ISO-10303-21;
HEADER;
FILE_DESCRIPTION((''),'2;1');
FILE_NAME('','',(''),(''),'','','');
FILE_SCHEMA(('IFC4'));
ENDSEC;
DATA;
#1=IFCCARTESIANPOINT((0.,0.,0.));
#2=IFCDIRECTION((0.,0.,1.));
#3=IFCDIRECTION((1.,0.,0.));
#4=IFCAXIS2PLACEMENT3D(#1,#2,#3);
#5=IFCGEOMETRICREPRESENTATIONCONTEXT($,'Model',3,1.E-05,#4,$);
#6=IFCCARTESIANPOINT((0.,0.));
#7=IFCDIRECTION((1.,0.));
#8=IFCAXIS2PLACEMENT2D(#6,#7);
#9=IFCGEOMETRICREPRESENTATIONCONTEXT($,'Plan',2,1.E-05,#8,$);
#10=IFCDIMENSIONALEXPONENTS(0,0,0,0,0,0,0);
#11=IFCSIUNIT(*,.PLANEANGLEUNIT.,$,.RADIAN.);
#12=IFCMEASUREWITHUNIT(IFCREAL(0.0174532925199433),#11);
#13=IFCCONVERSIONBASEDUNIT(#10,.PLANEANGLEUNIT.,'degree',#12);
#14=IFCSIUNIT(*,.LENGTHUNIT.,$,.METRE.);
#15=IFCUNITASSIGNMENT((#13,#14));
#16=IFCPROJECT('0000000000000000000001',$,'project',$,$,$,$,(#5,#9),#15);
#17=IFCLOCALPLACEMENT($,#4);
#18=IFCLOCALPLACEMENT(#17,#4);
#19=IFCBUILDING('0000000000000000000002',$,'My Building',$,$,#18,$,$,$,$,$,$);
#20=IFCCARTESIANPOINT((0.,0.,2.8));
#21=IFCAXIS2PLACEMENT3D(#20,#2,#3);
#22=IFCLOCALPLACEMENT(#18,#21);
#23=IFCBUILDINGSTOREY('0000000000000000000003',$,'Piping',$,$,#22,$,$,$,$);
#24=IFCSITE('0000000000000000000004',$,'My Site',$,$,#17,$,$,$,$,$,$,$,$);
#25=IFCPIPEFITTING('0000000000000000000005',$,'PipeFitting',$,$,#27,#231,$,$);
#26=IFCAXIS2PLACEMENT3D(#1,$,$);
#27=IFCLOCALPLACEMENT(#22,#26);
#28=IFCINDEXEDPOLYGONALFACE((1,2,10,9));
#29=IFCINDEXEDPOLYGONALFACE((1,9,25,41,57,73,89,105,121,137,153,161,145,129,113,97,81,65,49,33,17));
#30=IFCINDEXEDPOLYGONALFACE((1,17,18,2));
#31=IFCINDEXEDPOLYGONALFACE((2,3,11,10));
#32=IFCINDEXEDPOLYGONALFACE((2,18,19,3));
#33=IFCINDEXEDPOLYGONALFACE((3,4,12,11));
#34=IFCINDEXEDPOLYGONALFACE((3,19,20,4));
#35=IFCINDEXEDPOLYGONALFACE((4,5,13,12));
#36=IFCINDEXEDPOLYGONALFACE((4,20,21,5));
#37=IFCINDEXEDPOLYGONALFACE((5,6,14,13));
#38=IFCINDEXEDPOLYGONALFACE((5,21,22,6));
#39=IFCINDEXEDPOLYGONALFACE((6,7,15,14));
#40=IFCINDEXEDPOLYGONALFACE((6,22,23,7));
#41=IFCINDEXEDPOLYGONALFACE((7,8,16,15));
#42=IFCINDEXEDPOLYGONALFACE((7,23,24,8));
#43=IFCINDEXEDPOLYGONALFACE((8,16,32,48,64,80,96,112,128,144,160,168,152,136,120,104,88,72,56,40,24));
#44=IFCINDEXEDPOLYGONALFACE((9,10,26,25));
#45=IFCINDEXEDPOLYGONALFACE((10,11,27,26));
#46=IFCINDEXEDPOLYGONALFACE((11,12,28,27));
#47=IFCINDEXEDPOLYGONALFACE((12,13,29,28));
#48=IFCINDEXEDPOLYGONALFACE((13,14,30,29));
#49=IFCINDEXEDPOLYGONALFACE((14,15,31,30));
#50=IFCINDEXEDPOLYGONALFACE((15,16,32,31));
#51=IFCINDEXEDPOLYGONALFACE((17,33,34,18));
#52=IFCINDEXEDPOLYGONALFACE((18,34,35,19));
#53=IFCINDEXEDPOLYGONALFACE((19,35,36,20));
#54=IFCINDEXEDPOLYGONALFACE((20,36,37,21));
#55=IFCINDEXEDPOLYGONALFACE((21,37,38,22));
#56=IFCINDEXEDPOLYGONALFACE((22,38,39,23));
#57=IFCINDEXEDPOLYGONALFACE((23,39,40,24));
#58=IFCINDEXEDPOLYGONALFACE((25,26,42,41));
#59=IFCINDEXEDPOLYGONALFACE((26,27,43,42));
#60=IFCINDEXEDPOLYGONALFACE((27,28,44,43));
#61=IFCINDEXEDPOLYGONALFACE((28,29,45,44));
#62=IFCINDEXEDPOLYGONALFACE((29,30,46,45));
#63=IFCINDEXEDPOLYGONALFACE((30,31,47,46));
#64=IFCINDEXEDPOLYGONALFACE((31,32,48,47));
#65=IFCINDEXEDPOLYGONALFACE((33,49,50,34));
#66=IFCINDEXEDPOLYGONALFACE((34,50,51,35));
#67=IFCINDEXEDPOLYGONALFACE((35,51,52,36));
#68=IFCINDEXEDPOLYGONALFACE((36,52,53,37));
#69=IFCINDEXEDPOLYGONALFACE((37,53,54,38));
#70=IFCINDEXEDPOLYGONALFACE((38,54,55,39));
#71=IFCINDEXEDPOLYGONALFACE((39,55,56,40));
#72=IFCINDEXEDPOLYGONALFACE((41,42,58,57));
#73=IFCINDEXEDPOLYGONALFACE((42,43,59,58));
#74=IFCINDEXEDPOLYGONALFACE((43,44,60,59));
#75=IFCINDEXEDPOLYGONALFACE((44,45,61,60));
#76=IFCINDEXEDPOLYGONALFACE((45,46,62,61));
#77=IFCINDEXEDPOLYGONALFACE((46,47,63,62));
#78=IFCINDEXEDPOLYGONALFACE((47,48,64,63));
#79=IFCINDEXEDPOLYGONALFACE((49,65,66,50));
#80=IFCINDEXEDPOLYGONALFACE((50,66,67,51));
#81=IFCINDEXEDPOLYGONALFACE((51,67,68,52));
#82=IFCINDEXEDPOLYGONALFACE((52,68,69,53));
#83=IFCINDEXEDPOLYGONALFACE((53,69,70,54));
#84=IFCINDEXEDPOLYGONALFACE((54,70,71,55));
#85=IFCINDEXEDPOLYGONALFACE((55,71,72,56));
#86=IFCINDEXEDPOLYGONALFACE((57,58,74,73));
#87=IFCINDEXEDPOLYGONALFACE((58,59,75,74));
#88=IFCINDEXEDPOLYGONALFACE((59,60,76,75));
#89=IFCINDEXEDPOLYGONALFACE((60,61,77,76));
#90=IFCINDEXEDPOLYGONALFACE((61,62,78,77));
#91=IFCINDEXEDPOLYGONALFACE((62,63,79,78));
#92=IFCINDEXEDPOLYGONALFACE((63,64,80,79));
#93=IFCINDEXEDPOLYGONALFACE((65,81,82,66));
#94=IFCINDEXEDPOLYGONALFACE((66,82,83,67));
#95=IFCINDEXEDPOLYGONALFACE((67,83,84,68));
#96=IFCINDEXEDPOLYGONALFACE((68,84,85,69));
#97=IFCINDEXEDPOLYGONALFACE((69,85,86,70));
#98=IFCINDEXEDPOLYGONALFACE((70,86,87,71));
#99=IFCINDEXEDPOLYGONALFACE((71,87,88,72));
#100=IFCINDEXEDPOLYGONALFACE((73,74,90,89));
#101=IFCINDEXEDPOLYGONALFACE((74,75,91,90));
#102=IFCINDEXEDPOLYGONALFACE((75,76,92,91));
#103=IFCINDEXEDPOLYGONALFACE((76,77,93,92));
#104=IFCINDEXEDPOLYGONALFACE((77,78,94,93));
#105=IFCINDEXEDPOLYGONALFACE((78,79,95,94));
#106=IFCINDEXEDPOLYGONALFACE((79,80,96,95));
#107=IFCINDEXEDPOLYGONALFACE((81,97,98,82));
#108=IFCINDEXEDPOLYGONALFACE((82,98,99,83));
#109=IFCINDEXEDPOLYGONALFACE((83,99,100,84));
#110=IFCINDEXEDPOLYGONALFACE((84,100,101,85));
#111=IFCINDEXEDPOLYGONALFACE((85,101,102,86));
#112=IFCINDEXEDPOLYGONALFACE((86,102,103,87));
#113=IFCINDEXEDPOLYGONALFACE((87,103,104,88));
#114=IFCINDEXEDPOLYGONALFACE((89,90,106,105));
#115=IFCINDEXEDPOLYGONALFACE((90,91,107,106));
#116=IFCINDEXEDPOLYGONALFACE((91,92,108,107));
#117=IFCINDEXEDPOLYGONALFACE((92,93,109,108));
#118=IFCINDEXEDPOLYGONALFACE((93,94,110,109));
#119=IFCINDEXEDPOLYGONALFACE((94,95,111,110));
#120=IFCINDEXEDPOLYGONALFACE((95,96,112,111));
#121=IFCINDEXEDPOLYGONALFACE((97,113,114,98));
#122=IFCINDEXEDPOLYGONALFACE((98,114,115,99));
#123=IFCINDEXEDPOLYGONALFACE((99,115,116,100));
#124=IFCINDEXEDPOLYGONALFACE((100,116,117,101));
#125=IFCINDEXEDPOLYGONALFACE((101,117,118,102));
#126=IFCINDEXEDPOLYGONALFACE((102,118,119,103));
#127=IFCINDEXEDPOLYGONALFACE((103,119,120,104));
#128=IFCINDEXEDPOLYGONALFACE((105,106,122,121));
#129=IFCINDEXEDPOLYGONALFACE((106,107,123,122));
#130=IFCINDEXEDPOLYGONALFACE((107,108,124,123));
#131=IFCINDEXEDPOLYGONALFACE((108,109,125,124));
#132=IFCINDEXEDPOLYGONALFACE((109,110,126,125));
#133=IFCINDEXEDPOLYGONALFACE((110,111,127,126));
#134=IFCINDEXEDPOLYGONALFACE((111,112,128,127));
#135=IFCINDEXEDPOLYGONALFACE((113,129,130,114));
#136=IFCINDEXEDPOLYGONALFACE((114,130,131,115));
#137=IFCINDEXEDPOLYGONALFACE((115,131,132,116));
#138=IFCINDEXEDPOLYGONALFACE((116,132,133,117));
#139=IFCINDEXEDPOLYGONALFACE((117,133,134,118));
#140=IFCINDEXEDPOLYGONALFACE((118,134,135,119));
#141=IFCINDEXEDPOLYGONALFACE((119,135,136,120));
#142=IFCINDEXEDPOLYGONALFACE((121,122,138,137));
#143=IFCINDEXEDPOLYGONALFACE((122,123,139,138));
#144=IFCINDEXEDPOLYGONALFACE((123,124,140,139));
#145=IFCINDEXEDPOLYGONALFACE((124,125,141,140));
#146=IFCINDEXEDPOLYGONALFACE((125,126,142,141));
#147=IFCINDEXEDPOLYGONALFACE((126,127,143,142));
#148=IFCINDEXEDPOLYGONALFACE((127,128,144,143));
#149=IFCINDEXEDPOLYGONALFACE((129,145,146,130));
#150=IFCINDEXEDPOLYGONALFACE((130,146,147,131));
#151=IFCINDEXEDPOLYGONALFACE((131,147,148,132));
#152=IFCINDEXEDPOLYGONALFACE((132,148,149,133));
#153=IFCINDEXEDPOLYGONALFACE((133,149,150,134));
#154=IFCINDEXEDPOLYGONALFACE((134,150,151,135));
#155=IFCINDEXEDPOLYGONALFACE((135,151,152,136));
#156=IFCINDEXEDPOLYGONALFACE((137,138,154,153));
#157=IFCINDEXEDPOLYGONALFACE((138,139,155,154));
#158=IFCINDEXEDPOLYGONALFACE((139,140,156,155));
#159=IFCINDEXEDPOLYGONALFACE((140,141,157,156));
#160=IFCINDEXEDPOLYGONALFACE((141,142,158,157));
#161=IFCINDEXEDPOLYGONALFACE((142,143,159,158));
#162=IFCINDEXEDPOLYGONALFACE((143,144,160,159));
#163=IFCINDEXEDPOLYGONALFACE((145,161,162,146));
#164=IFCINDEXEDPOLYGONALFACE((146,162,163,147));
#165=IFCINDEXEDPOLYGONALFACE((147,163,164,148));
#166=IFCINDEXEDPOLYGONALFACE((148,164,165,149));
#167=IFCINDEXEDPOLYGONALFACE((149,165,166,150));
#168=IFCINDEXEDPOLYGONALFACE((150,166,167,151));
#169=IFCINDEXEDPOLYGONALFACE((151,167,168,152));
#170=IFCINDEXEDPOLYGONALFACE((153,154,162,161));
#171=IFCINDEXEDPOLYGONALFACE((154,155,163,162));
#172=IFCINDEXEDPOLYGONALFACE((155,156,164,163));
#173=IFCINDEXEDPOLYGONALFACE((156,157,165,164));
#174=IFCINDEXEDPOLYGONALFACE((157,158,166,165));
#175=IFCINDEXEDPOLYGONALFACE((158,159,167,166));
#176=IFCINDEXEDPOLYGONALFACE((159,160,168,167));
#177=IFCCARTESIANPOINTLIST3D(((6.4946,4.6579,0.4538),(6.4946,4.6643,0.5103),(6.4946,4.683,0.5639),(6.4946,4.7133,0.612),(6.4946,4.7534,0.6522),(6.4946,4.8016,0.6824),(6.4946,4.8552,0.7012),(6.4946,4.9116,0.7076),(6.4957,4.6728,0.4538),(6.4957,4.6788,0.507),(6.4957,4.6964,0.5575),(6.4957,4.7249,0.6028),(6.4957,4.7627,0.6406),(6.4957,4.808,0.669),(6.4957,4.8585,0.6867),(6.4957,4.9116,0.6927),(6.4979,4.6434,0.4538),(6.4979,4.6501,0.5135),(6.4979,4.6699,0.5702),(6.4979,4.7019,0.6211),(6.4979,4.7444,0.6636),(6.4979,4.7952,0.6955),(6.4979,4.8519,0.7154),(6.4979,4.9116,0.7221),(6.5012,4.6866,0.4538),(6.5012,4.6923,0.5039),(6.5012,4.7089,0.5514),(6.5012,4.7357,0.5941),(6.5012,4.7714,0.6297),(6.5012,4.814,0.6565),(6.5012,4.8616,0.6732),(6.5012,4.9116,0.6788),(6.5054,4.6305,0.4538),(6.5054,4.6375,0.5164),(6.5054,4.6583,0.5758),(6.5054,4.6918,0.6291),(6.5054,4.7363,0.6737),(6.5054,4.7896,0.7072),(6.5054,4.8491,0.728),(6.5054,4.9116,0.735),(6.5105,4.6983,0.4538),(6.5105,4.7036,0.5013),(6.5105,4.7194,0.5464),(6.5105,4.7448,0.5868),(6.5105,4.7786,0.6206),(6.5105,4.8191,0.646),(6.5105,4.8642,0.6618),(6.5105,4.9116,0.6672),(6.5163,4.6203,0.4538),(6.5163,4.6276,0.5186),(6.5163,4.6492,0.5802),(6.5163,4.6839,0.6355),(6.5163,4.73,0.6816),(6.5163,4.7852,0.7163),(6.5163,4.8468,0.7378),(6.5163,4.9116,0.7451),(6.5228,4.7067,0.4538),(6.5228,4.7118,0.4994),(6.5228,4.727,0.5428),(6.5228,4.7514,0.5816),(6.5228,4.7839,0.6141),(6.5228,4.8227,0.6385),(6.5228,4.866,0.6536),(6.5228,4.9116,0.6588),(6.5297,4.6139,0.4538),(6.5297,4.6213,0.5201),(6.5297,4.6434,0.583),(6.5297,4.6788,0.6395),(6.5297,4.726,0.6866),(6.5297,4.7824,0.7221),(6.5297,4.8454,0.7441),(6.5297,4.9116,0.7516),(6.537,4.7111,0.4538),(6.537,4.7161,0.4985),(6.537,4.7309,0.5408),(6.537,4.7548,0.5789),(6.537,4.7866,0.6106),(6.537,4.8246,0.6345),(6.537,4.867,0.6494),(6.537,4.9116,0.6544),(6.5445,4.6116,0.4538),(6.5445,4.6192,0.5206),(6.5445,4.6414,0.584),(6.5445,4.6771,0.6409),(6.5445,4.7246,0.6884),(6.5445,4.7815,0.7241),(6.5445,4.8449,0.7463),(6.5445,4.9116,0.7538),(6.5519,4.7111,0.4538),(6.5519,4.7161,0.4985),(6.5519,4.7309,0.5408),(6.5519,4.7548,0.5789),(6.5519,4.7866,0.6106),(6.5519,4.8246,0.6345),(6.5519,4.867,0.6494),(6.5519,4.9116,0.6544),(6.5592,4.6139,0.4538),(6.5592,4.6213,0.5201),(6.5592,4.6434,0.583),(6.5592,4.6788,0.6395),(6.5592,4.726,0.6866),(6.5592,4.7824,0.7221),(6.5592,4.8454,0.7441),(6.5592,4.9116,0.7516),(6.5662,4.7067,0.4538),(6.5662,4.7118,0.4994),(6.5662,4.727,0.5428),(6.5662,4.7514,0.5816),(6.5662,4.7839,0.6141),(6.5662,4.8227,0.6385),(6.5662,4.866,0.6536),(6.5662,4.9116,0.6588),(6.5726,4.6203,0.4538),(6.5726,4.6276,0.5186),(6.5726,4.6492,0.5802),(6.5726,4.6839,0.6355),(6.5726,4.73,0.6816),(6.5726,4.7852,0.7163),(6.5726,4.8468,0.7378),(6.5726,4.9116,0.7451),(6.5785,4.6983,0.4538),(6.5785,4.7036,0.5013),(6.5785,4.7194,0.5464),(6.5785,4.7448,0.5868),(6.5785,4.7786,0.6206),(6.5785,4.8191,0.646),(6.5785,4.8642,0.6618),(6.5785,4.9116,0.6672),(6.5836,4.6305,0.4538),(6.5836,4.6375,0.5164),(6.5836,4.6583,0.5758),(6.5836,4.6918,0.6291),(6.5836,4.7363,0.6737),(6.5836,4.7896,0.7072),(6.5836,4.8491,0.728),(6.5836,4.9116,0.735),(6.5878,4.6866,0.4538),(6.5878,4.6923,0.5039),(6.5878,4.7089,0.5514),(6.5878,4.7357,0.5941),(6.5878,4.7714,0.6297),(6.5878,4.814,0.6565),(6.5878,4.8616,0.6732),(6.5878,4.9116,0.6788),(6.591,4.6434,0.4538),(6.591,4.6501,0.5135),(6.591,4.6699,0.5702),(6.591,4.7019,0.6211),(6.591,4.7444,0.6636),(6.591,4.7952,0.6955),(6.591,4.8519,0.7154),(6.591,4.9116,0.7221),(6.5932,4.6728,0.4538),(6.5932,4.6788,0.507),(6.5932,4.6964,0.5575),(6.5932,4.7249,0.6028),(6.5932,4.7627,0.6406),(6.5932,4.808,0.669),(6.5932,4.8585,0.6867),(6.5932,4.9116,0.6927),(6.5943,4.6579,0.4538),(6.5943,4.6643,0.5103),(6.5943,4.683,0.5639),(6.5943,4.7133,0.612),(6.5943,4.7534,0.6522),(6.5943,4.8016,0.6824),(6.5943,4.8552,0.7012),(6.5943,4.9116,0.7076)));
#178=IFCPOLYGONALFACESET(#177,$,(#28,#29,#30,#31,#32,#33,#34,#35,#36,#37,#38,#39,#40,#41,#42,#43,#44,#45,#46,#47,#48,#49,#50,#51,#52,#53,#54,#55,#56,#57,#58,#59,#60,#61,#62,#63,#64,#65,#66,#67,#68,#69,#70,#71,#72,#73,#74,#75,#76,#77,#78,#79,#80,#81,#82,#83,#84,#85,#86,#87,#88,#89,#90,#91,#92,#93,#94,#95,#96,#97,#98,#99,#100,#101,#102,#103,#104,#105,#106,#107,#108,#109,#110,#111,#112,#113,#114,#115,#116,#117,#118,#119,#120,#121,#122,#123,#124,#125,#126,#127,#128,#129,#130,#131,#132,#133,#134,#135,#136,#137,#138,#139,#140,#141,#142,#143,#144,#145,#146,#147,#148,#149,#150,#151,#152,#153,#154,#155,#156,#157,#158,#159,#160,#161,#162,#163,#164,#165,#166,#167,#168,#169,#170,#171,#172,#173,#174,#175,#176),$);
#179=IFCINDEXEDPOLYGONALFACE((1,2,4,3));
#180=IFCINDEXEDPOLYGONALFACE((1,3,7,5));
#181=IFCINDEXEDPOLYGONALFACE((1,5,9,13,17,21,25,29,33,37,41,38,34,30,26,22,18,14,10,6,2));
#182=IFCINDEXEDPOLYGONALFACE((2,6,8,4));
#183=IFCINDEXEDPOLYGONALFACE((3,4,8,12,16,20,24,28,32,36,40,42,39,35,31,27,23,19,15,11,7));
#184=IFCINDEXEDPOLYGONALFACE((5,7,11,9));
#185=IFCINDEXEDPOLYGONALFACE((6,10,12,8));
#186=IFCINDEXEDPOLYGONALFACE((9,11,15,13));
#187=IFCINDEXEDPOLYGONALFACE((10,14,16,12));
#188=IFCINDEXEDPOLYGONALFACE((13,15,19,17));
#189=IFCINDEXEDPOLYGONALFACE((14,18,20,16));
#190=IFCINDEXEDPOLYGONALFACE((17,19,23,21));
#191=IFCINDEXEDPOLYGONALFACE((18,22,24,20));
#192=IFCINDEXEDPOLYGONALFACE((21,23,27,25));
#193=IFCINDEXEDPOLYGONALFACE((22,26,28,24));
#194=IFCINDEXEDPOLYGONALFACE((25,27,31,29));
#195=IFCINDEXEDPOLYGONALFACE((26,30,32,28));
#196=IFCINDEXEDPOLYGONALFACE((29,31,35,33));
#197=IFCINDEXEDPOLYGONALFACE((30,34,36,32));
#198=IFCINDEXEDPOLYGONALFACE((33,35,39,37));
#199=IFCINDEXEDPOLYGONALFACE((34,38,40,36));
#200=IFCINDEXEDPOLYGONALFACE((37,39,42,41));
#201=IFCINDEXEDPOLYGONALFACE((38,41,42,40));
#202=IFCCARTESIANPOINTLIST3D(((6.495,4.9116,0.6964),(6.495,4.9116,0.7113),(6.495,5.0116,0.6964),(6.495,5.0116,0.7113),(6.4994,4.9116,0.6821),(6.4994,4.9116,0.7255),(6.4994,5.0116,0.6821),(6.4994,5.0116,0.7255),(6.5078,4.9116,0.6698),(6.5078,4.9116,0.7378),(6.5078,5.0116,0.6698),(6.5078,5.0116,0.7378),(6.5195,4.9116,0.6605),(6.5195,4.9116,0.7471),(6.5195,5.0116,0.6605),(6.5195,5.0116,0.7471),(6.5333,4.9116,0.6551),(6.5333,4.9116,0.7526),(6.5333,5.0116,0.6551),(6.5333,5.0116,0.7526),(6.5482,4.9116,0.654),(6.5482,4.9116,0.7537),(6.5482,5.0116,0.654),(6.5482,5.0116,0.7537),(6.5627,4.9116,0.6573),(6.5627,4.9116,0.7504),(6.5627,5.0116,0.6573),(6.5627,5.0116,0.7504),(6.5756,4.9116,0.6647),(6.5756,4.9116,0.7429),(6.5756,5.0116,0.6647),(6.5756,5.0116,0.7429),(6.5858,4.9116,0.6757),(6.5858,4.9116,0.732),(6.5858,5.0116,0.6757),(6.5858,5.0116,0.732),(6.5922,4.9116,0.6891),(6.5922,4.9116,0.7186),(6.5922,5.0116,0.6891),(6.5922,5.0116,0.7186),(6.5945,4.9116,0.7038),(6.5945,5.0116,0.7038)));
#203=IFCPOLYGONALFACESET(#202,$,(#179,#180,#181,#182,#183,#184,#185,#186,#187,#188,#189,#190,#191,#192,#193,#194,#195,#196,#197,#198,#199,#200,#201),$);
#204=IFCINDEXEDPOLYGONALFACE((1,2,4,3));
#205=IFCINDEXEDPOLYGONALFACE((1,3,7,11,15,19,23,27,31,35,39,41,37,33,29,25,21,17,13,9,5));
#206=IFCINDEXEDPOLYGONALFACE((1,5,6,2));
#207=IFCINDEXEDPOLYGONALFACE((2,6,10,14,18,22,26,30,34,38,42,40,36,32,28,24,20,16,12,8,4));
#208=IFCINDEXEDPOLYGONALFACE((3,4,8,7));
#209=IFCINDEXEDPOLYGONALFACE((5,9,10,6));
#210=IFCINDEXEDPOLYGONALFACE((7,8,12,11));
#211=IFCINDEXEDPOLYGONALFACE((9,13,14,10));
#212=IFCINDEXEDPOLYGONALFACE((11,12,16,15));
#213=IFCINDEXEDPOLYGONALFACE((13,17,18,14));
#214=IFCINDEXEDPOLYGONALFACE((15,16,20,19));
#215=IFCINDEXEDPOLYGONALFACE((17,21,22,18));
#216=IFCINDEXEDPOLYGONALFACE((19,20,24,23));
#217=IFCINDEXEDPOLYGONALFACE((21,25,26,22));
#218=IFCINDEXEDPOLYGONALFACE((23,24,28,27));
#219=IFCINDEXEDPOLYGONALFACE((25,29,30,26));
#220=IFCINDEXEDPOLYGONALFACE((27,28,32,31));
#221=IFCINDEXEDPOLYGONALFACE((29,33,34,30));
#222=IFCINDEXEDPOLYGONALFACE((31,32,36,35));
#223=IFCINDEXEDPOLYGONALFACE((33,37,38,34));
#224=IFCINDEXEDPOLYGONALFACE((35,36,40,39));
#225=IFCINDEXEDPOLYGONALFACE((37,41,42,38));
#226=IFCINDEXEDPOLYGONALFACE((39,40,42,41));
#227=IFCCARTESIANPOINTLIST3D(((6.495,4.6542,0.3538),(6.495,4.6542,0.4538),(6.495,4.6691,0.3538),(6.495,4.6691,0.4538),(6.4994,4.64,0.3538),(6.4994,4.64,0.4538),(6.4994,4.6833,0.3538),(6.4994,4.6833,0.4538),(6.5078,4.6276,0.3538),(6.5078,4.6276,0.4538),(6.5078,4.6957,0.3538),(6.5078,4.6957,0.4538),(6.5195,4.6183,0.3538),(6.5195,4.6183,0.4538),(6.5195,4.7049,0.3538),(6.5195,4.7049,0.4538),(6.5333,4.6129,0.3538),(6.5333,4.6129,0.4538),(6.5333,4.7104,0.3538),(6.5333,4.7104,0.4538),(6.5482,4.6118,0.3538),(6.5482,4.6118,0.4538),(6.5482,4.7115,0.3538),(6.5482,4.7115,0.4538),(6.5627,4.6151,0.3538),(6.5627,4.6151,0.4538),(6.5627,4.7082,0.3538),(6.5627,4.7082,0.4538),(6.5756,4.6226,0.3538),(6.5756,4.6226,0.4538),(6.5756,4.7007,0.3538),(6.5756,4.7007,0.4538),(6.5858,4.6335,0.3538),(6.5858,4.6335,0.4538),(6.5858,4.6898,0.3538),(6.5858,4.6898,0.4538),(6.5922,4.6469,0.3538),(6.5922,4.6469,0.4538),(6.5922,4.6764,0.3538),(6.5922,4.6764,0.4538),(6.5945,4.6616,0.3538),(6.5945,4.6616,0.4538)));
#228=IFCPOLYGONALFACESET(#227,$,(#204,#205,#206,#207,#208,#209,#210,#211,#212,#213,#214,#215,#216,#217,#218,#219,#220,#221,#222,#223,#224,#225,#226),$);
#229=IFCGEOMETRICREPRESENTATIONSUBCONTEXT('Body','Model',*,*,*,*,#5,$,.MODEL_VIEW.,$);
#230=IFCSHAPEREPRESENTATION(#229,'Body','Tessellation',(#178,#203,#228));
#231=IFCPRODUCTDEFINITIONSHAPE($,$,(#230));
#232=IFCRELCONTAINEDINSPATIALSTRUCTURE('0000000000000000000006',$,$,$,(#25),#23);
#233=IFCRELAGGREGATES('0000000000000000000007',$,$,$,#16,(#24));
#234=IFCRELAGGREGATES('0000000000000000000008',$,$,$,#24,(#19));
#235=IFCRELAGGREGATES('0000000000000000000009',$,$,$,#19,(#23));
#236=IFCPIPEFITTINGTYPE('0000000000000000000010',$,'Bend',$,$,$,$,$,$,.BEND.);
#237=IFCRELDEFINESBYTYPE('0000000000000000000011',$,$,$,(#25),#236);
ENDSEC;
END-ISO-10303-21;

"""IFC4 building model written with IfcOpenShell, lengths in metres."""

from ifc_helpers import new_model, entity, si_unit, converted_unit, frame, origin_with_axes, origin_2d_with_axis, place, context, subcontext, project, spatial, circle, extrude, source, transform, mapped, type_object, type_shapes, element, save


model = new_model("IFC4")

# Units and contexts
model_context = context("Model", 3, precision=1e-05, world=origin_with_axes())
plan_context = context("Plan", 2, precision=1e-05, world=origin_2d_with_axis())
body_context = subcontext(model_context, "Body", "Model", "MODEL_VIEW")
ifc_project = project(units=[converted_unit("PLANEANGLEUNIT", "degree", entity("IfcReal", 0.0174532925199433), si_unit("PLANEANGLEUNIT", "RADIAN"), dimensions=[0, 0, 0, 0, 0, 0, 0]), si_unit("LENGTHUNIT", "METRE")], contexts=[model_context, plan_context])

# Site, building, storey
site_placement = place(None, origin_with_axes())
site = spatial("IfcSite", under=ifc_project, at=site_placement, Name="My Site")
building_placement = place(site_placement, origin_with_axes())
building = spatial("IfcBuilding", under=site, at=building_placement, Name="My Building")
storey_placement = place(building_placement, frame((0.0, 0.0, 2.8), z_axis=(0.0, 0.0, 1.0), x_axis=(1.0, 0.0, 0.0)))
storey = spatial("IfcBuildingStorey", under=building, at=storey_placement, Name="Piping")

# Pipe fitting
pipe_fitting_type_1 = type_object("IfcPipeFittingType", Name="Bend", PredefinedType="BEND")
shared_shape = source(origin_with_axes(), body_context, "Body", "SolidModel", [
    entity("IfcSweptDiskSolid", entity("IfcIndexedPolyCurve", entity("IfcCartesianPointList3D", [[0.0, 0.0, 0.1], [0.0, -0.0732, 0.2768], [0.0, -0.25, 0.35]]), [entity("IfcArcIndex", [1, 2, 3])]), 0.05),
    extrude(circle(Radius=0.05), origin_with_axes(), (0.0, 0.0, 1.0), 0.1),
    extrude(circle(Radius=0.05), frame((0.0, -0.25, 0.35), z_axis=(0.0, -1.0, 0.0), x_axis=(1.0, 0.0, 0.0)), (0.0, 0.0, 1.0), 0.1),
])
type_shapes(pipe_fitting_type_1, [shared_shape])
for number, where, z_axis, x_axis, name in (
    (1, (6.5445, 5.0116, 0.7038), (0.0, -1.0, 0.0), (1.0, 0.0, 0.0), "PipeFitting"),
):
    element("IfcPipeFitting", number, at=place(storey_placement, frame(where, z_axis=z_axis, x_axis=x_axis)), inside=storey, type_object=pipe_fitting_type_1, Name=name, context=body_context, shape_type="MappedRepresentation", body=[
        mapped(shared_shape, transform((0.0, 0.0, 0.0), x_axis=(1.0, 0.0, 0.0), y_axis=(0.0, 1.0, 0.0), z_axis=(0.0, 0.0, 1.0), scale=1.0)),
    ])

save(model, "model.ifc")
